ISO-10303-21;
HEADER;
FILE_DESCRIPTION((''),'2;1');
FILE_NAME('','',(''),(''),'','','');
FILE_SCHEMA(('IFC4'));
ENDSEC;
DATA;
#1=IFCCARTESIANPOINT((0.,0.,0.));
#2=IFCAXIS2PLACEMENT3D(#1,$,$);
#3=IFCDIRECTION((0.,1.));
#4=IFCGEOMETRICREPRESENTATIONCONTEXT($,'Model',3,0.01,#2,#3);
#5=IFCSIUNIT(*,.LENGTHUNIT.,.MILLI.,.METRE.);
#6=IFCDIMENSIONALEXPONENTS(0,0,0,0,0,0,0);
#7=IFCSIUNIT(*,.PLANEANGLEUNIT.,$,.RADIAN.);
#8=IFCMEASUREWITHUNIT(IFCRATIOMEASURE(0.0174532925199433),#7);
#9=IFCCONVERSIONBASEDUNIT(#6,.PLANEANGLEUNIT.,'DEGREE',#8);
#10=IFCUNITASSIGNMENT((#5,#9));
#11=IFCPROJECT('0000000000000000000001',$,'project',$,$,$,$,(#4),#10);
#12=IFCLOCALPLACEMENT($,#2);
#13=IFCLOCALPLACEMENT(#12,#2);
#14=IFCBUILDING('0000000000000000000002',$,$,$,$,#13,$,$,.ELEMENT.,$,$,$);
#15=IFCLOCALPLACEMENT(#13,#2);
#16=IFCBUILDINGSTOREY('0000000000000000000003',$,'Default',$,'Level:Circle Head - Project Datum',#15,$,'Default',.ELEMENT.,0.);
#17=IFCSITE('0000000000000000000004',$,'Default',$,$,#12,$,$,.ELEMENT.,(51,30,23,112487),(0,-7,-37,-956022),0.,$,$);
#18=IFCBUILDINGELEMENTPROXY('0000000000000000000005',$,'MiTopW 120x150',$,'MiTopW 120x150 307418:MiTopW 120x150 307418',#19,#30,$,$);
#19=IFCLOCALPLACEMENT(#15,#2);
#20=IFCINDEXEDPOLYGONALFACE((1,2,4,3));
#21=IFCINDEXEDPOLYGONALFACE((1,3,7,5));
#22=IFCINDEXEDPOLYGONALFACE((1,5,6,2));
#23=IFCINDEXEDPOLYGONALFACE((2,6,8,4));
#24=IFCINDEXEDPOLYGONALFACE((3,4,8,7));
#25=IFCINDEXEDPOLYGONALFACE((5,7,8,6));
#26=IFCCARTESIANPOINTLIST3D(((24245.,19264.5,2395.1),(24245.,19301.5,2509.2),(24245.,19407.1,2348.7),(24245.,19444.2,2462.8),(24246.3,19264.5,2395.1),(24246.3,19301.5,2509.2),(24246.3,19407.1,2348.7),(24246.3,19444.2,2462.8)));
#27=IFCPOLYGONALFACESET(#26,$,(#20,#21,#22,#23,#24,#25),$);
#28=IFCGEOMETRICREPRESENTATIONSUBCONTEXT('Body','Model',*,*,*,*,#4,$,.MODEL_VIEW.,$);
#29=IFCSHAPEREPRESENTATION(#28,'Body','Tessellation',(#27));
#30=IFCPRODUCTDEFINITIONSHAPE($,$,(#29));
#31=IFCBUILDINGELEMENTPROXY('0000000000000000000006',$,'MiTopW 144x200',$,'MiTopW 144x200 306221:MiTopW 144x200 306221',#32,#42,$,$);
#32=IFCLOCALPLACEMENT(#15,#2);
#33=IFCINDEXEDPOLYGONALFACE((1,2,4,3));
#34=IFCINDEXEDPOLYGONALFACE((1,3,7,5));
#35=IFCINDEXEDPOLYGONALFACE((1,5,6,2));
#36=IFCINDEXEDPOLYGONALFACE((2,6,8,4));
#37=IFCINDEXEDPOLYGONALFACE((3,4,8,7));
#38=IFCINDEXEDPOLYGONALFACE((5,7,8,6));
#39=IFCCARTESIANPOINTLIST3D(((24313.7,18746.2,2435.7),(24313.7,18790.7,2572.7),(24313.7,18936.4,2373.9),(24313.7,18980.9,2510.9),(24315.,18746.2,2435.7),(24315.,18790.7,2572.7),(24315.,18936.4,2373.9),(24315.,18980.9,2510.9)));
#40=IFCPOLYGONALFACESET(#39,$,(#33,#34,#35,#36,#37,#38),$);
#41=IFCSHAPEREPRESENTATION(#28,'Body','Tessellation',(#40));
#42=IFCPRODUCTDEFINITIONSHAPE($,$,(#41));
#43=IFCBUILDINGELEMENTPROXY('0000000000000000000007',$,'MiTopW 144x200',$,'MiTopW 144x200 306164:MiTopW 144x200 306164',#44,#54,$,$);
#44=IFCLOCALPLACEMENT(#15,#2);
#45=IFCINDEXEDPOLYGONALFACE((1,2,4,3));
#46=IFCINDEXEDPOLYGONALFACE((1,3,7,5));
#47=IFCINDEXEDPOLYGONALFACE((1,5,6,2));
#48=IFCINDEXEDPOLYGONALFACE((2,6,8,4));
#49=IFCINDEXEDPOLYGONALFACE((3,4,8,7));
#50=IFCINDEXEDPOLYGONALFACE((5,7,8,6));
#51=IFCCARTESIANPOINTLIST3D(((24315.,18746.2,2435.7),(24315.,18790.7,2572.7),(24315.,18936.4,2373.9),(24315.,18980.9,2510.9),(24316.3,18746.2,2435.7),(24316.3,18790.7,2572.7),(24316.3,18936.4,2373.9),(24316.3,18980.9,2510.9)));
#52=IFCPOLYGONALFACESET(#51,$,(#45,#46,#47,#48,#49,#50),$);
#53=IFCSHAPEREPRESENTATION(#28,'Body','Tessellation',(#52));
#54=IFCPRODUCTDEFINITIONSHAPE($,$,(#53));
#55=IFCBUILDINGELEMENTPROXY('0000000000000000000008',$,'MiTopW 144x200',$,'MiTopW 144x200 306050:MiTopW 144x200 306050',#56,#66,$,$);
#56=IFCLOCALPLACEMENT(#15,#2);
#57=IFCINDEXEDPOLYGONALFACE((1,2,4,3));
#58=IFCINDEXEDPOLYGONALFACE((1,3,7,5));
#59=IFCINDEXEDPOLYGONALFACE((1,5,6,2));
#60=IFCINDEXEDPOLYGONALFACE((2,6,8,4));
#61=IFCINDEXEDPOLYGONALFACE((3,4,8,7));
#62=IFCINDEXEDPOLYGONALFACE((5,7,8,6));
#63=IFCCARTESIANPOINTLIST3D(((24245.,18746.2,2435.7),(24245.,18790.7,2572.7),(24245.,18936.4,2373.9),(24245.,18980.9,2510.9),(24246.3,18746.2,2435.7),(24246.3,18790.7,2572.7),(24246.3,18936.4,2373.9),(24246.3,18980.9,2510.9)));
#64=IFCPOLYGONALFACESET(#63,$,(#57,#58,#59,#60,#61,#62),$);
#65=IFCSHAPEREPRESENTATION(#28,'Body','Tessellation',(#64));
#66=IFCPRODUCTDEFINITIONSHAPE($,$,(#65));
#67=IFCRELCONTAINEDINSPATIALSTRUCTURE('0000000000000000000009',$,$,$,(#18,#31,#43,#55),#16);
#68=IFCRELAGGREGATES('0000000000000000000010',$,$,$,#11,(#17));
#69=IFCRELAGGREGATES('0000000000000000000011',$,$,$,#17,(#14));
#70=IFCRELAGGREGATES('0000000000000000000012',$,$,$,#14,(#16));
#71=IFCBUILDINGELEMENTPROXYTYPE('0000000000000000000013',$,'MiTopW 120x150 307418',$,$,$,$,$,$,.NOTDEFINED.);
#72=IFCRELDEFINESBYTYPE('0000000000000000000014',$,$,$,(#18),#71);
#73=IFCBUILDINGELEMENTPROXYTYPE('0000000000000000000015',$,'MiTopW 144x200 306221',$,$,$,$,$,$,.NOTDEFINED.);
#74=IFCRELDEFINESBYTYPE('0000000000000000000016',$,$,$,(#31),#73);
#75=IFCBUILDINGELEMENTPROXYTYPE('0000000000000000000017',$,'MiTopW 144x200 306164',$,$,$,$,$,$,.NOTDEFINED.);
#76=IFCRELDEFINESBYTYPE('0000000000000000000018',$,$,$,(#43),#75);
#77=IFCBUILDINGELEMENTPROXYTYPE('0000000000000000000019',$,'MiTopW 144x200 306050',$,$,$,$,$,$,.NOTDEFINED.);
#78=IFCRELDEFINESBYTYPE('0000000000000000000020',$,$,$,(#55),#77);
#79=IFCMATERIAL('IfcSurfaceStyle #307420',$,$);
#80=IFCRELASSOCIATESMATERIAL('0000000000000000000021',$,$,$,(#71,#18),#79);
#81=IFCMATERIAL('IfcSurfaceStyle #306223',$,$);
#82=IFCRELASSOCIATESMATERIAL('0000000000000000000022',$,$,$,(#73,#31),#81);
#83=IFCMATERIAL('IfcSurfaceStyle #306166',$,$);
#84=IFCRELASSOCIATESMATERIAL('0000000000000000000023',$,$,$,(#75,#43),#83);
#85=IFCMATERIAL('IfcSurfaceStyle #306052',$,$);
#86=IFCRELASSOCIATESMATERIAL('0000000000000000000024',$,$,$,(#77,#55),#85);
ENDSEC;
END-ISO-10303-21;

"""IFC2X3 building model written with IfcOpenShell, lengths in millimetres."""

from ifc_helpers import new_model, entity, si_unit, converted_unit, direction, frame, origin, place, context, subcontext, project, spatial, polyline, outline, extrude, source, transform, mapped, material, type_object, type_shapes, element, save


model = new_model("IFC2X3")

# Units and contexts
model_context = context("Model", 3, precision=0.01, world=origin(), true_north=direction((0.0, 1.0)))
body_context = subcontext(model_context, "Body", "Model", "MODEL_VIEW")
ifc_project = project(units=[si_unit("LENGTHUNIT", "METRE", prefix="MILLI"), converted_unit("PLANEANGLEUNIT", "DEGREE", entity("IfcRatioMeasure", 0.0174532925199433), si_unit("PLANEANGLEUNIT", "RADIAN"), dimensions=[0, 0, 0, 0, 0, 0, 0])], contexts=[model_context])

# Site, building, storey
site_placement = place(None, origin())
site = spatial("IfcSite", under=ifc_project, at=site_placement, Name="Default", CompositionType="ELEMENT", RefLatitude=(51, 30, 23, 112487), RefLongitude=(0, -7, -37, -956022), RefElevation=0.0)
building_placement = place(site_placement, origin())
building = spatial("IfcBuilding", under=site, at=building_placement, CompositionType="ELEMENT")
storey_placement = place(building_placement, origin())
storey = spatial("IfcBuildingStorey", under=building, at=storey_placement, Name="Default", ObjectType="Level:Circle Head - Project Datum", LongName="Default", CompositionType="ELEMENT", Elevation=0.0)

# Building element proxies
ifc_material_1 = material(Name="IfcSurfaceStyle #307420")
building_element_proxy_type_1 = type_object("IfcBuildingElementProxyType", Name="MiTopW 120x150 307418", PredefinedType="NOTDEFINED", material=ifc_material_1)
shared_shape_1 = source(origin(), body_context, "Body", "SweptSolid", [
    extrude(outline(polyline([(-75.0, -60.0), (75.0, -60.0), (75.0, 60.0), (-75.0, 60.0), (-75.0, -60.0)])), frame((75.0, 60.0, 0.0), z_axis=(0.0, 0.0, 1.0), x_axis=(-1.0, 0.0, 0.0)), (0.0, 0.0, 1.0), 1.3),
])
type_shapes(building_element_proxy_type_1, [shared_shape_1])
proxy_1_placement = place(building_placement, frame((24246.3, 19407.1, 2348.7), z_axis=(-1.0, 0.0, 0.0), x_axis=(0.0, -0.951057, 0.309017)))
element("IfcBuildingElementProxy", 1, at=proxy_1_placement, inside=storey, type_object=building_element_proxy_type_1, material=ifc_material_1, Name="MiTopW 120x150", ObjectType="MiTopW 120x150 307418:MiTopW 120x150 307418", context=body_context, shape_type="MappedRepresentation", body=[
    mapped(shared_shape_1, transform((0.0, 0.0, 0.0), scale=1.0)),
])
ifc_material_2 = material(Name="IfcSurfaceStyle #306223")
building_element_proxy_type_2 = type_object("IfcBuildingElementProxyType", Name="MiTopW 144x200 306221", PredefinedType="NOTDEFINED", material=ifc_material_2)
shared_shape_2 = source(origin(), body_context, "Body", "SweptSolid", [
    extrude(outline(polyline([(-100.0, -72.0), (100.0, -72.0), (100.0, 72.0), (-100.0, 72.0), (-100.0, -72.0)])), frame((100.0, 72.0, 0.0), z_axis=(0.0, 0.0, 1.0), x_axis=(-1.0, 0.0, 0.0)), (0.0, 0.0, 1.0), 1.3),
])
type_shapes(building_element_proxy_type_2, [shared_shape_2])
proxy_2_placement = place(building_placement, frame((24315.0, 18936.4, 2373.9), z_axis=(-1.0, 0.0, 0.0), x_axis=(0.0, -0.951057, 0.309017)))
element("IfcBuildingElementProxy", 2, at=proxy_2_placement, inside=storey, type_object=building_element_proxy_type_2, material=ifc_material_2, Name="MiTopW 144x200", ObjectType="MiTopW 144x200 306221:MiTopW 144x200 306221", context=body_context, shape_type="MappedRepresentation", body=[
    mapped(shared_shape_2, transform((0.0, 0.0, 0.0), scale=1.0)),
])
ifc_material_3 = material(Name="IfcSurfaceStyle #306166")
building_element_proxy_type_3 = type_object("IfcBuildingElementProxyType", Name="MiTopW 144x200 306164", PredefinedType="NOTDEFINED", material=ifc_material_3)
shared_shape_3 = source(origin(), body_context, "Body", "SweptSolid", [
    extrude(outline(polyline([(-100.0, -72.0), (100.0, -72.0), (100.0, 72.0), (-100.0, 72.0), (-100.0, -72.0)])), frame((100.0, 72.0, 0.0), z_axis=(0.0, 0.0, 1.0), x_axis=(-1.0, 0.0, 0.0)), (0.0, 0.0, 1.0), 1.3),
])
type_shapes(building_element_proxy_type_3, [shared_shape_3])
proxy_3_placement = place(building_placement, frame((24316.3, 18936.4, 2373.9), z_axis=(-1.0, 0.0, 0.0), x_axis=(0.0, -0.951057, 0.309017)))
element("IfcBuildingElementProxy", 3, at=proxy_3_placement, inside=storey, type_object=building_element_proxy_type_3, material=ifc_material_3, Name="MiTopW 144x200", ObjectType="MiTopW 144x200 306164:MiTopW 144x200 306164", context=body_context, shape_type="MappedRepresentation", body=[
    mapped(shared_shape_3, transform((0.0, 0.0, 0.0), scale=1.0)),
])
ifc_material_4 = material(Name="IfcSurfaceStyle #306052")
building_element_proxy_type_4 = type_object("IfcBuildingElementProxyType", Name="MiTopW 144x200 306050", PredefinedType="NOTDEFINED", material=ifc_material_4)
shared_shape_4 = source(origin(), body_context, "Body", "SweptSolid", [
    extrude(outline(polyline([(-100.0, -72.0), (100.0, -72.0), (100.0, 72.0), (-100.0, 72.0), (-100.0, -72.0)])), frame((100.0, 72.0, 0.0), z_axis=(0.0, 0.0, 1.0), x_axis=(-1.0, 0.0, 0.0)), (0.0, 0.0, 1.0), 1.3),
])
type_shapes(building_element_proxy_type_4, [shared_shape_4])
proxy_4_placement = place(building_placement, frame((24246.3, 18936.4, 2373.9), z_axis=(-1.0, 0.0, 0.0), x_axis=(0.0, -0.951057, 0.309017)))
element("IfcBuildingElementProxy", 4, at=proxy_4_placement, inside=storey, type_object=building_element_proxy_type_4, material=ifc_material_4, Name="MiTopW 144x200", ObjectType="MiTopW 144x200 306050:MiTopW 144x200 306050", context=body_context, shape_type="MappedRepresentation", body=[
    mapped(shared_shape_4, transform((0.0, 0.0, 0.0), scale=1.0)),
])

save(model, "model.ifc")
